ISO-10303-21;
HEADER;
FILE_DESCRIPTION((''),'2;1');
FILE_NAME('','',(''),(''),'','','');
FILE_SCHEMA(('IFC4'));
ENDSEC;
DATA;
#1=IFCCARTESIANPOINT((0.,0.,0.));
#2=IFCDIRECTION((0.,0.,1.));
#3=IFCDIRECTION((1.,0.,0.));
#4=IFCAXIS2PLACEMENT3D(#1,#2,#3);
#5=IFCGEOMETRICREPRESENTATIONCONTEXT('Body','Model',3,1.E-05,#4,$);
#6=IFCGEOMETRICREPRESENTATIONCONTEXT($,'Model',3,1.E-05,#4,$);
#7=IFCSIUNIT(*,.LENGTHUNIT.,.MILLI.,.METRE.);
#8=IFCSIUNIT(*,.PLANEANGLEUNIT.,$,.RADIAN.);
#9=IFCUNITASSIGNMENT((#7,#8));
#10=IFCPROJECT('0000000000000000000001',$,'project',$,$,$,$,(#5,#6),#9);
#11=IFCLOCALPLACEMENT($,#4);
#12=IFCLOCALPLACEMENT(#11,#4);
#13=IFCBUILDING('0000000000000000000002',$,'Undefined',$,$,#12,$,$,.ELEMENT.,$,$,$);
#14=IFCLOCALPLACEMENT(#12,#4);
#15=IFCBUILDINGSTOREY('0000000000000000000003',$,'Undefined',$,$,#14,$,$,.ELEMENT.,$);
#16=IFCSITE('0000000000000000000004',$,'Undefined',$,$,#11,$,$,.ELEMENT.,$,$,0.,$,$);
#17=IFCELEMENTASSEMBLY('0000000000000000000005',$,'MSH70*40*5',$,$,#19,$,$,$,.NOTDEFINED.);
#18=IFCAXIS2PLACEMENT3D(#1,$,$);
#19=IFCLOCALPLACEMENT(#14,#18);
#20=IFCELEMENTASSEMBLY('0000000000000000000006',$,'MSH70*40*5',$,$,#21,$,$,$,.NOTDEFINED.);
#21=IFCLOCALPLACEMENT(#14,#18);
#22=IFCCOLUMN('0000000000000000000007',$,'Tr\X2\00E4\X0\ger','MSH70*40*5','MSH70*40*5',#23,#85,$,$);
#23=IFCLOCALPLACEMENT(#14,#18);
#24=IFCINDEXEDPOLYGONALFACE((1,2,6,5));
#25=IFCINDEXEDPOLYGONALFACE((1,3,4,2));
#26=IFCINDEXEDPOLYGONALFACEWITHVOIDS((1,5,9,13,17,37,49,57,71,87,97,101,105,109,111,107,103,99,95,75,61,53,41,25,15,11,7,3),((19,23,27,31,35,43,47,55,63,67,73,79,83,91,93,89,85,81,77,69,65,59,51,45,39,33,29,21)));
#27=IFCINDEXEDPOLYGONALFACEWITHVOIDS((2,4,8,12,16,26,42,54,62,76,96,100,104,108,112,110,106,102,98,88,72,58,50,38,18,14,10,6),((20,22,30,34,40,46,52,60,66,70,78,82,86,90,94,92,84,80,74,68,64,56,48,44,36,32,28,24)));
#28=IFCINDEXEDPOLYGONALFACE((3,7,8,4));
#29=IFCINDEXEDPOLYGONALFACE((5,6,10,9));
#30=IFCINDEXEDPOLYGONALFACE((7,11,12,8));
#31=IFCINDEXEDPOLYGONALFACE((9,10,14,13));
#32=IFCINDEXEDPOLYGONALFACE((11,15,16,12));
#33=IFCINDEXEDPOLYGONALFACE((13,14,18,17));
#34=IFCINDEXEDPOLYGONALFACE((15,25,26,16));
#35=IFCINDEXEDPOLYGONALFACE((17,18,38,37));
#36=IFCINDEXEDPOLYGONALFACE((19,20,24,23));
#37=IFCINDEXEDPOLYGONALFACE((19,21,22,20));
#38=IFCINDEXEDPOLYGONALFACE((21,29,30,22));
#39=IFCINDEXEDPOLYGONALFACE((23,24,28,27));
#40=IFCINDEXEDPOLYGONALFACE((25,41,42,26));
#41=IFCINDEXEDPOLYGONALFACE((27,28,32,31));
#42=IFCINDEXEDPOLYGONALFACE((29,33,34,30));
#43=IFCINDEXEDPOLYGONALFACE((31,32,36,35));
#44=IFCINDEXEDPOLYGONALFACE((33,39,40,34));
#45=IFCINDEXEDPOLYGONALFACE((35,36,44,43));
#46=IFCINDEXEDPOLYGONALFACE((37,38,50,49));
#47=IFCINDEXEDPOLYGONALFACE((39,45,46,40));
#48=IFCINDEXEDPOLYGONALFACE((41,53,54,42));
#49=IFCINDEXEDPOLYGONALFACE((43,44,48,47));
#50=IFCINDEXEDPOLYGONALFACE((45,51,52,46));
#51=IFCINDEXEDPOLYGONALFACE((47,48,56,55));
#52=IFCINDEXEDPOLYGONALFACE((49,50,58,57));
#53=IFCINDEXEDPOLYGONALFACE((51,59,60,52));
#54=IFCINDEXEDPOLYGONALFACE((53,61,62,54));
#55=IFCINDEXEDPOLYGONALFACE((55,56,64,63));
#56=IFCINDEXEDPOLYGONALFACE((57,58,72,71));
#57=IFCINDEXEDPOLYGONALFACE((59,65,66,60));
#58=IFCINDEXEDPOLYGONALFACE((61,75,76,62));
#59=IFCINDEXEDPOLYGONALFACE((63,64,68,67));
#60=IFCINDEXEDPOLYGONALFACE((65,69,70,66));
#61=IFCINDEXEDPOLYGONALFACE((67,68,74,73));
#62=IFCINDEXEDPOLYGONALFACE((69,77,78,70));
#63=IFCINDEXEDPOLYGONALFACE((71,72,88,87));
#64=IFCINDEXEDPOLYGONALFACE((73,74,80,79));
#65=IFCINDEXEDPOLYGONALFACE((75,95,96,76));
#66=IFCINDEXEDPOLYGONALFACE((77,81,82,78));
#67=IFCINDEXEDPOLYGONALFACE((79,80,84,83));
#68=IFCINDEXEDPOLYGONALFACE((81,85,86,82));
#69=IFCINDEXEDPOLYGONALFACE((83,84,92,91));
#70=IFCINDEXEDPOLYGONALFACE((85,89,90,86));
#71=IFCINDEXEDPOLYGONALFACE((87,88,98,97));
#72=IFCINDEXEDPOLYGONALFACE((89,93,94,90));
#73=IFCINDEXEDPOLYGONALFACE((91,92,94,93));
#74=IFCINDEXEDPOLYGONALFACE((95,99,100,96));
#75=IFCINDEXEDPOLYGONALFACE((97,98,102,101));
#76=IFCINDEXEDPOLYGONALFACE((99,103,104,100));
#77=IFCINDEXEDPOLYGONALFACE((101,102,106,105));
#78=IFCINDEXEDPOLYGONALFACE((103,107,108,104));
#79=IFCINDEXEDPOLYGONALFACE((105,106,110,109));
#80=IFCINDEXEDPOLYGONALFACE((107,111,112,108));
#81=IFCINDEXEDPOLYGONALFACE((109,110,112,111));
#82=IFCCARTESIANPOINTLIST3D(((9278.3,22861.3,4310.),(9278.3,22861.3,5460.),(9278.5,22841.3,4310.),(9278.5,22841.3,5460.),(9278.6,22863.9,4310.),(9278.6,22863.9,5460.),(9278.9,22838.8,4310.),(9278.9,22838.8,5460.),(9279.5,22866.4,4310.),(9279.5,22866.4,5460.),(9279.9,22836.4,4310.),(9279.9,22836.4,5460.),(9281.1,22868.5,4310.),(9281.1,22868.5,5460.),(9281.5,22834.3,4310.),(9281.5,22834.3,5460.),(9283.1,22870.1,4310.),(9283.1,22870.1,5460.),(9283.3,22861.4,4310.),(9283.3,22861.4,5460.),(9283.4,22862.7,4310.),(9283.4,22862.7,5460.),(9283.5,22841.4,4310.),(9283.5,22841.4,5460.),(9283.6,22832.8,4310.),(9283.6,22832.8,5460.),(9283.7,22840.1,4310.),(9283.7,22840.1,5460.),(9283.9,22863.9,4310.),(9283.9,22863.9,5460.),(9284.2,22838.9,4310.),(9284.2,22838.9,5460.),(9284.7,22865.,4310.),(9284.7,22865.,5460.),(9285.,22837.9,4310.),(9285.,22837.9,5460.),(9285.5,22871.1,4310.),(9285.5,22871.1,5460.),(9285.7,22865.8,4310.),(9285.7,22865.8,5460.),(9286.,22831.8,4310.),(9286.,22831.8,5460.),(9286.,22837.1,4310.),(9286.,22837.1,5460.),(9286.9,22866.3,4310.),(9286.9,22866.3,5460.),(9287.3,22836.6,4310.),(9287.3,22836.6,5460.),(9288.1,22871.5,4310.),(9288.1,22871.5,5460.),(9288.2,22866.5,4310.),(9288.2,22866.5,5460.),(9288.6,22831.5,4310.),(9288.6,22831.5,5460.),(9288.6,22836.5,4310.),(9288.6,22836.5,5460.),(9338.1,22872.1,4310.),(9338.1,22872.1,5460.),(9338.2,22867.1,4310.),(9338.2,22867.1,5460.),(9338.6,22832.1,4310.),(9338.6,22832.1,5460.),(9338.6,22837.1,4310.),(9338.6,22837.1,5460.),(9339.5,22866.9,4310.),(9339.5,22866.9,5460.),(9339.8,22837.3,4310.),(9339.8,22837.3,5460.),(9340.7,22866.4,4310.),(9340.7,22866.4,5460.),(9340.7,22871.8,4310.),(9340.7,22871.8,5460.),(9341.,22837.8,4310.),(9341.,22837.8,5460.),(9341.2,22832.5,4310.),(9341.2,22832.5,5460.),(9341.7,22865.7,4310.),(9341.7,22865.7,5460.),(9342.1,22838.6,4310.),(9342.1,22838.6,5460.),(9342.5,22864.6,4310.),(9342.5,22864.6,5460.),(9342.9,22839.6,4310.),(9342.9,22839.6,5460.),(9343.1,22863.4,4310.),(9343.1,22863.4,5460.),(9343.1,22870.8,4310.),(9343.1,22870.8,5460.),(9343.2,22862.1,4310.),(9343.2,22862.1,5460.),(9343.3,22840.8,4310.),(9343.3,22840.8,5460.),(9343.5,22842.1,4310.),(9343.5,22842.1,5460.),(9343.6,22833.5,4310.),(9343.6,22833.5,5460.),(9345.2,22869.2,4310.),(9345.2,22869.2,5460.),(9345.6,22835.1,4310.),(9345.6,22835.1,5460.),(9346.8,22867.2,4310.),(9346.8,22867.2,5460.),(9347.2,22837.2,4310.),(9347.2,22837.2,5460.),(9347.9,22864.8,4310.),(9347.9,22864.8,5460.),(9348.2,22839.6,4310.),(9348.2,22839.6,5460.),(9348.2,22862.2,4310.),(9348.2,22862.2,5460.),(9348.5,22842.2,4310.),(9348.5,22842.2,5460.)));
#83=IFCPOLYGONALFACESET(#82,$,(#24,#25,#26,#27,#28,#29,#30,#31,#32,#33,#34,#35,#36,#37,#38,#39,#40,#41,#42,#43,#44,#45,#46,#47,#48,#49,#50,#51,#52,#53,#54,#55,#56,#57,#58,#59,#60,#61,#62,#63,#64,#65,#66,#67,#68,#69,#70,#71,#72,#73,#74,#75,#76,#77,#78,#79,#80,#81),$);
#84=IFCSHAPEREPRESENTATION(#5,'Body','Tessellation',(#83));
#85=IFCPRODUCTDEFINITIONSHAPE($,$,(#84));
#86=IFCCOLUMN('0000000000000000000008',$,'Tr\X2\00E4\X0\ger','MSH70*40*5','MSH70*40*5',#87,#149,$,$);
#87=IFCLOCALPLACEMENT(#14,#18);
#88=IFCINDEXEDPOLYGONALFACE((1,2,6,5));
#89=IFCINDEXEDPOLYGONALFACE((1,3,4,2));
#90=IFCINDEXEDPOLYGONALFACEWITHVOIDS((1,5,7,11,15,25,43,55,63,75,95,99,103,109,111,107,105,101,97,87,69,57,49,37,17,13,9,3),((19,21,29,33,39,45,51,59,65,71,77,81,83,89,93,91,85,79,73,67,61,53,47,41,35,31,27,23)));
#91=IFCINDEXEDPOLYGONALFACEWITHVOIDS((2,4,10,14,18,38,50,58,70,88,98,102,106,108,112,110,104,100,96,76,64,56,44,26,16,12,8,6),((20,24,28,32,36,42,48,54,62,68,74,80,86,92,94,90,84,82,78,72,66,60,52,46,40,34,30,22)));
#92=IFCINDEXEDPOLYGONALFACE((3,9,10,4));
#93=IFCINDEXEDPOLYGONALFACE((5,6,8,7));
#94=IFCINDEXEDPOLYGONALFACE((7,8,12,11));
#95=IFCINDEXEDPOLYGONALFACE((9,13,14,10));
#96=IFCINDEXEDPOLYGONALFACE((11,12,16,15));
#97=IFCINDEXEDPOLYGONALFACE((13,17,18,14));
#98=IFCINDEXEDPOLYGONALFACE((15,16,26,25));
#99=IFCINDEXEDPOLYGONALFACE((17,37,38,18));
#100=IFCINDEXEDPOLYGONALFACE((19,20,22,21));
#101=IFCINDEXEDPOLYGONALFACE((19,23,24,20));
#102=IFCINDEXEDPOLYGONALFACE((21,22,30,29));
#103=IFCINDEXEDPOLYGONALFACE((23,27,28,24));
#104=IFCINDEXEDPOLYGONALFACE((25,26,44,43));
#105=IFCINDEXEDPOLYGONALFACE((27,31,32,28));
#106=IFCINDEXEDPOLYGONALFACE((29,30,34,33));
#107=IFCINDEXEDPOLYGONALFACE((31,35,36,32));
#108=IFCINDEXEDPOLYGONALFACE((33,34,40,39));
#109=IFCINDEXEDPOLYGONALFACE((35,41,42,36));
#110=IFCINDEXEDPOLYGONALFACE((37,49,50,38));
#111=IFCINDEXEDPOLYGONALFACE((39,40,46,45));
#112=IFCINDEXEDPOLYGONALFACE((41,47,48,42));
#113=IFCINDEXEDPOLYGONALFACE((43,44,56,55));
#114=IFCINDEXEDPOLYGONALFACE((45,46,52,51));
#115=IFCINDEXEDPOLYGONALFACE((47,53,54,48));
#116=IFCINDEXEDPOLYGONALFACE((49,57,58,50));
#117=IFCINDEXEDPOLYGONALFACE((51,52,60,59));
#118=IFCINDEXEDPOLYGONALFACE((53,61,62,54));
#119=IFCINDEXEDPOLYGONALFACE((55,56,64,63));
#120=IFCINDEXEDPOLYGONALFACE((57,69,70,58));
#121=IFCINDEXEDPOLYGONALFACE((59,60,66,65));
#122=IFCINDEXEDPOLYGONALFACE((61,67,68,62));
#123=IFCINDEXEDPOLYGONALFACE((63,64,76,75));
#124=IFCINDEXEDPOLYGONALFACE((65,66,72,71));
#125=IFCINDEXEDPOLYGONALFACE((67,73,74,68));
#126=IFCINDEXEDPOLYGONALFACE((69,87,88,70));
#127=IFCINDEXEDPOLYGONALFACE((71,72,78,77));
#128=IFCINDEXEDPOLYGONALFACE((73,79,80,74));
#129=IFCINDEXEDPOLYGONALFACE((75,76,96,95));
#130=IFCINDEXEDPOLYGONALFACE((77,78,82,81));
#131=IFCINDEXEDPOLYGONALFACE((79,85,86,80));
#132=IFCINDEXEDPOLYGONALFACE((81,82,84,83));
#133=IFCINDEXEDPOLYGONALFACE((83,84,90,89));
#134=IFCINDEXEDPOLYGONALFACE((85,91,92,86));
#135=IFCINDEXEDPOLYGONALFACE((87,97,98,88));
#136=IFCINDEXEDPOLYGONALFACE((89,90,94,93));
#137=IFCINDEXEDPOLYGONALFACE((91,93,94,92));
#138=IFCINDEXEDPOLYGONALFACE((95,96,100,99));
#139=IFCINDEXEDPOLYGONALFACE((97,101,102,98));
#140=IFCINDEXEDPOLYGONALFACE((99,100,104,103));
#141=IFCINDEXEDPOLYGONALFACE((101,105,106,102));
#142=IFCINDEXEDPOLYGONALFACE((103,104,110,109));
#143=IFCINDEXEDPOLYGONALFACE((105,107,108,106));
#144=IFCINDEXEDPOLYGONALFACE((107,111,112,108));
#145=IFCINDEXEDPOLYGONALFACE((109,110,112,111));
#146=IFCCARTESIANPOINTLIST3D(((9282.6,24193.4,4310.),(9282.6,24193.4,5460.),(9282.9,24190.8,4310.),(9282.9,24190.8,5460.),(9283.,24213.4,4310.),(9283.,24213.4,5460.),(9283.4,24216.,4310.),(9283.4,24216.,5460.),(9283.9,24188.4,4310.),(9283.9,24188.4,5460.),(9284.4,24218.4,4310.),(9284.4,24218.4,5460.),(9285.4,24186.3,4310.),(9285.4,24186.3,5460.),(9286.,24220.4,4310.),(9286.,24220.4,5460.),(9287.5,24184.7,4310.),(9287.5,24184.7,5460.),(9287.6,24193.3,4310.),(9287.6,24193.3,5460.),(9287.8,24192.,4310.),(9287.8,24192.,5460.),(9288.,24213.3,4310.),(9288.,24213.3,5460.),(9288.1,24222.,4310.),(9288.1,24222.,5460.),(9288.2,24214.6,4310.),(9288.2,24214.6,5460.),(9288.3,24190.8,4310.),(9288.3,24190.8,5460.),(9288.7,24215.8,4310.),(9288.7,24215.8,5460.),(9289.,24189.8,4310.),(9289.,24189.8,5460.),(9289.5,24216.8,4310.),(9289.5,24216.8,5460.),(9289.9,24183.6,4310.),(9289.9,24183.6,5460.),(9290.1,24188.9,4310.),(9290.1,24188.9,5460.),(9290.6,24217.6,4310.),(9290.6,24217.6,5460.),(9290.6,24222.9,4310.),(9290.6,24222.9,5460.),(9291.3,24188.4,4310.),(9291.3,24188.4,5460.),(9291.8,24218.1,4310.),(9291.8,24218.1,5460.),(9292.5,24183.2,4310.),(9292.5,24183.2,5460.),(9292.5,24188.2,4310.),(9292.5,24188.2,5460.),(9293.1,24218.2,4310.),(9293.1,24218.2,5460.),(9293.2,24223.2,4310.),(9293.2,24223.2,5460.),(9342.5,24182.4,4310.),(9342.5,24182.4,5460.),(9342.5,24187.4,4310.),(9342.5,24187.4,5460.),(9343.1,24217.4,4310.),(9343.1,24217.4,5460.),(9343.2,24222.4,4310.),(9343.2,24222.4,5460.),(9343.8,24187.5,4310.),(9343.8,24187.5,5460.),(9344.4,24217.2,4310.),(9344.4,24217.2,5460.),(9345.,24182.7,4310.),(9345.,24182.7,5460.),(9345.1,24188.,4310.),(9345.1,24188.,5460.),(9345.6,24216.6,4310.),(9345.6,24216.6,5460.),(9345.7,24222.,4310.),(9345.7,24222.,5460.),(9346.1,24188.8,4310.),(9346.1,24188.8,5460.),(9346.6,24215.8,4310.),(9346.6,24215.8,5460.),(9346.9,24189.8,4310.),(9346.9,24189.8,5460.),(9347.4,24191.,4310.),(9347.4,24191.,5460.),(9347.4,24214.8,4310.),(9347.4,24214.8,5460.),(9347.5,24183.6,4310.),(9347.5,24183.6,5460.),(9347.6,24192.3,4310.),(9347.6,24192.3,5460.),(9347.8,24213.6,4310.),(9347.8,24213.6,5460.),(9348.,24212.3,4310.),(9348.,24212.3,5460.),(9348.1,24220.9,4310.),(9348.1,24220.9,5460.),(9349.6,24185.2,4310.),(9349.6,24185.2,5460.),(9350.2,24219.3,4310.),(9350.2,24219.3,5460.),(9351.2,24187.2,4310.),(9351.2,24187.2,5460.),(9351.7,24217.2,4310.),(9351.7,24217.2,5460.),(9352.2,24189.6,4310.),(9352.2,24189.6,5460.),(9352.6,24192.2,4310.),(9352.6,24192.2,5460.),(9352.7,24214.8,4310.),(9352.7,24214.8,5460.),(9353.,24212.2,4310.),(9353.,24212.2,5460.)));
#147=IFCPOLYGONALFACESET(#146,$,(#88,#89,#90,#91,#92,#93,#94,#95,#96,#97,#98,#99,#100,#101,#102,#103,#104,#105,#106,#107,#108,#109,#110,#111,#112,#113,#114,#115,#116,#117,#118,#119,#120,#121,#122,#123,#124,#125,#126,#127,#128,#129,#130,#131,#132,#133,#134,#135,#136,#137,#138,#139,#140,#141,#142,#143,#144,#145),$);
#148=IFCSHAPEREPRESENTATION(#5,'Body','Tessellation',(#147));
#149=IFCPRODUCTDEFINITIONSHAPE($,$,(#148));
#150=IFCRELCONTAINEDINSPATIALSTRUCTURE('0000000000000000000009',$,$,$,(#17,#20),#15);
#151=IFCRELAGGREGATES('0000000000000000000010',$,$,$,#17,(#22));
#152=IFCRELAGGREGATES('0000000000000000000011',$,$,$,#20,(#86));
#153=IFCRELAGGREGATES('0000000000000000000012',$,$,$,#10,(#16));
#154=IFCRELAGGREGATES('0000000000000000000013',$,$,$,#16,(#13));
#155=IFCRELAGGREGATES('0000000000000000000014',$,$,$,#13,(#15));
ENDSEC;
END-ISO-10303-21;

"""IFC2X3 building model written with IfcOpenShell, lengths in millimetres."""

from ifc_helpers import new_model, si_unit, frame, origin_with_axes, origin_2d_with_axis, place, context, project, spatial, hollow_rectangle, extrude, element, aggregate, save


model = new_model("IFC2X3")

# Units and contexts
model_context_1 = context("Model", 3, precision=1e-05, world=origin_with_axes(), identifier="Body")
model_context_2 = context("Model", 3, precision=1e-05, world=origin_with_axes())
ifc_project = project(units=[si_unit("LENGTHUNIT", "METRE", prefix="MILLI"), si_unit("PLANEANGLEUNIT", "RADIAN")], contexts=[model_context_1, model_context_2])

# Site, building, storey
site_placement = place(None, origin_with_axes())
site = spatial("IfcSite", under=ifc_project, at=site_placement, Name="Undefined", CompositionType="ELEMENT", RefElevation=0.0)
building_placement = place(site_placement, origin_with_axes())
building = spatial("IfcBuilding", under=site, at=building_placement, Name="Undefined", CompositionType="ELEMENT")
storey_placement = place(building_placement, origin_with_axes())
storey = spatial("IfcBuildingStorey", under=building, at=storey_placement, Name="Undefined", CompositionType="ELEMENT")

# Element assembly
assembly_1 = element("IfcElementAssembly", 1, inside=storey, Name="MSH70*40*5", PredefinedType="NOTDEFINED")

# Element assembly
assembly_2 = element("IfcElementAssembly", 2, inside=storey, Name="MSH70*40*5", PredefinedType="NOTDEFINED")

# Columns
column_1_placement = place(storey_placement, frame((9313.4, 22851.8, 4310.0), z_axis=(0.0, 0.0, 1.0), x_axis=(1.0, 0.0, 0.0)))
column_1 = element("IfcColumn", 3, at=column_1_placement, Name="Träger", Description="MSH70*40*5", ObjectType="MSH70*40*5", context=model_context_1, shape_type="SweptSolid", body=[
    extrude(hollow_rectangle(XDim=40.0, YDim=70.0, WallThickness=5.0, InnerFilletRadius=5.0, OuterFilletRadius=10.0, at=origin_2d_with_axis()), frame((0.0, 0.0, 1150.0), z_axis=(0.0, 0.0, -1.0), x_axis=(0.012217, -0.999925, 0.0)), (0.0, 0.0, 1.0), 1150.0),
])
aggregate(assembly_1, [column_1])
column_2_placement = place(storey_placement, frame((9317.8, 24202.8, 4310.0), z_axis=(0.0, 0.0, 1.0), x_axis=(1.0, 0.0, 0.0)))
column_2 = element("IfcColumn", 4, at=column_2_placement, Name="Träger", Description="MSH70*40*5", ObjectType="MSH70*40*5", context=model_context_1, shape_type="SweptSolid", body=[
    extrude(hollow_rectangle(XDim=40.0, YDim=70.0, WallThickness=5.0, InnerFilletRadius=5.0, OuterFilletRadius=10.0, at=origin_2d_with_axis()), frame((0.0, 0.0, 1150.0), z_axis=(0.0, 0.0, -1.0), x_axis=(-0.017453, -0.999848, 0.0)), (0.0, 0.0, 1.0), 1150.0),
])
aggregate(assembly_2, [column_2])

save(model, "model.ifc")
